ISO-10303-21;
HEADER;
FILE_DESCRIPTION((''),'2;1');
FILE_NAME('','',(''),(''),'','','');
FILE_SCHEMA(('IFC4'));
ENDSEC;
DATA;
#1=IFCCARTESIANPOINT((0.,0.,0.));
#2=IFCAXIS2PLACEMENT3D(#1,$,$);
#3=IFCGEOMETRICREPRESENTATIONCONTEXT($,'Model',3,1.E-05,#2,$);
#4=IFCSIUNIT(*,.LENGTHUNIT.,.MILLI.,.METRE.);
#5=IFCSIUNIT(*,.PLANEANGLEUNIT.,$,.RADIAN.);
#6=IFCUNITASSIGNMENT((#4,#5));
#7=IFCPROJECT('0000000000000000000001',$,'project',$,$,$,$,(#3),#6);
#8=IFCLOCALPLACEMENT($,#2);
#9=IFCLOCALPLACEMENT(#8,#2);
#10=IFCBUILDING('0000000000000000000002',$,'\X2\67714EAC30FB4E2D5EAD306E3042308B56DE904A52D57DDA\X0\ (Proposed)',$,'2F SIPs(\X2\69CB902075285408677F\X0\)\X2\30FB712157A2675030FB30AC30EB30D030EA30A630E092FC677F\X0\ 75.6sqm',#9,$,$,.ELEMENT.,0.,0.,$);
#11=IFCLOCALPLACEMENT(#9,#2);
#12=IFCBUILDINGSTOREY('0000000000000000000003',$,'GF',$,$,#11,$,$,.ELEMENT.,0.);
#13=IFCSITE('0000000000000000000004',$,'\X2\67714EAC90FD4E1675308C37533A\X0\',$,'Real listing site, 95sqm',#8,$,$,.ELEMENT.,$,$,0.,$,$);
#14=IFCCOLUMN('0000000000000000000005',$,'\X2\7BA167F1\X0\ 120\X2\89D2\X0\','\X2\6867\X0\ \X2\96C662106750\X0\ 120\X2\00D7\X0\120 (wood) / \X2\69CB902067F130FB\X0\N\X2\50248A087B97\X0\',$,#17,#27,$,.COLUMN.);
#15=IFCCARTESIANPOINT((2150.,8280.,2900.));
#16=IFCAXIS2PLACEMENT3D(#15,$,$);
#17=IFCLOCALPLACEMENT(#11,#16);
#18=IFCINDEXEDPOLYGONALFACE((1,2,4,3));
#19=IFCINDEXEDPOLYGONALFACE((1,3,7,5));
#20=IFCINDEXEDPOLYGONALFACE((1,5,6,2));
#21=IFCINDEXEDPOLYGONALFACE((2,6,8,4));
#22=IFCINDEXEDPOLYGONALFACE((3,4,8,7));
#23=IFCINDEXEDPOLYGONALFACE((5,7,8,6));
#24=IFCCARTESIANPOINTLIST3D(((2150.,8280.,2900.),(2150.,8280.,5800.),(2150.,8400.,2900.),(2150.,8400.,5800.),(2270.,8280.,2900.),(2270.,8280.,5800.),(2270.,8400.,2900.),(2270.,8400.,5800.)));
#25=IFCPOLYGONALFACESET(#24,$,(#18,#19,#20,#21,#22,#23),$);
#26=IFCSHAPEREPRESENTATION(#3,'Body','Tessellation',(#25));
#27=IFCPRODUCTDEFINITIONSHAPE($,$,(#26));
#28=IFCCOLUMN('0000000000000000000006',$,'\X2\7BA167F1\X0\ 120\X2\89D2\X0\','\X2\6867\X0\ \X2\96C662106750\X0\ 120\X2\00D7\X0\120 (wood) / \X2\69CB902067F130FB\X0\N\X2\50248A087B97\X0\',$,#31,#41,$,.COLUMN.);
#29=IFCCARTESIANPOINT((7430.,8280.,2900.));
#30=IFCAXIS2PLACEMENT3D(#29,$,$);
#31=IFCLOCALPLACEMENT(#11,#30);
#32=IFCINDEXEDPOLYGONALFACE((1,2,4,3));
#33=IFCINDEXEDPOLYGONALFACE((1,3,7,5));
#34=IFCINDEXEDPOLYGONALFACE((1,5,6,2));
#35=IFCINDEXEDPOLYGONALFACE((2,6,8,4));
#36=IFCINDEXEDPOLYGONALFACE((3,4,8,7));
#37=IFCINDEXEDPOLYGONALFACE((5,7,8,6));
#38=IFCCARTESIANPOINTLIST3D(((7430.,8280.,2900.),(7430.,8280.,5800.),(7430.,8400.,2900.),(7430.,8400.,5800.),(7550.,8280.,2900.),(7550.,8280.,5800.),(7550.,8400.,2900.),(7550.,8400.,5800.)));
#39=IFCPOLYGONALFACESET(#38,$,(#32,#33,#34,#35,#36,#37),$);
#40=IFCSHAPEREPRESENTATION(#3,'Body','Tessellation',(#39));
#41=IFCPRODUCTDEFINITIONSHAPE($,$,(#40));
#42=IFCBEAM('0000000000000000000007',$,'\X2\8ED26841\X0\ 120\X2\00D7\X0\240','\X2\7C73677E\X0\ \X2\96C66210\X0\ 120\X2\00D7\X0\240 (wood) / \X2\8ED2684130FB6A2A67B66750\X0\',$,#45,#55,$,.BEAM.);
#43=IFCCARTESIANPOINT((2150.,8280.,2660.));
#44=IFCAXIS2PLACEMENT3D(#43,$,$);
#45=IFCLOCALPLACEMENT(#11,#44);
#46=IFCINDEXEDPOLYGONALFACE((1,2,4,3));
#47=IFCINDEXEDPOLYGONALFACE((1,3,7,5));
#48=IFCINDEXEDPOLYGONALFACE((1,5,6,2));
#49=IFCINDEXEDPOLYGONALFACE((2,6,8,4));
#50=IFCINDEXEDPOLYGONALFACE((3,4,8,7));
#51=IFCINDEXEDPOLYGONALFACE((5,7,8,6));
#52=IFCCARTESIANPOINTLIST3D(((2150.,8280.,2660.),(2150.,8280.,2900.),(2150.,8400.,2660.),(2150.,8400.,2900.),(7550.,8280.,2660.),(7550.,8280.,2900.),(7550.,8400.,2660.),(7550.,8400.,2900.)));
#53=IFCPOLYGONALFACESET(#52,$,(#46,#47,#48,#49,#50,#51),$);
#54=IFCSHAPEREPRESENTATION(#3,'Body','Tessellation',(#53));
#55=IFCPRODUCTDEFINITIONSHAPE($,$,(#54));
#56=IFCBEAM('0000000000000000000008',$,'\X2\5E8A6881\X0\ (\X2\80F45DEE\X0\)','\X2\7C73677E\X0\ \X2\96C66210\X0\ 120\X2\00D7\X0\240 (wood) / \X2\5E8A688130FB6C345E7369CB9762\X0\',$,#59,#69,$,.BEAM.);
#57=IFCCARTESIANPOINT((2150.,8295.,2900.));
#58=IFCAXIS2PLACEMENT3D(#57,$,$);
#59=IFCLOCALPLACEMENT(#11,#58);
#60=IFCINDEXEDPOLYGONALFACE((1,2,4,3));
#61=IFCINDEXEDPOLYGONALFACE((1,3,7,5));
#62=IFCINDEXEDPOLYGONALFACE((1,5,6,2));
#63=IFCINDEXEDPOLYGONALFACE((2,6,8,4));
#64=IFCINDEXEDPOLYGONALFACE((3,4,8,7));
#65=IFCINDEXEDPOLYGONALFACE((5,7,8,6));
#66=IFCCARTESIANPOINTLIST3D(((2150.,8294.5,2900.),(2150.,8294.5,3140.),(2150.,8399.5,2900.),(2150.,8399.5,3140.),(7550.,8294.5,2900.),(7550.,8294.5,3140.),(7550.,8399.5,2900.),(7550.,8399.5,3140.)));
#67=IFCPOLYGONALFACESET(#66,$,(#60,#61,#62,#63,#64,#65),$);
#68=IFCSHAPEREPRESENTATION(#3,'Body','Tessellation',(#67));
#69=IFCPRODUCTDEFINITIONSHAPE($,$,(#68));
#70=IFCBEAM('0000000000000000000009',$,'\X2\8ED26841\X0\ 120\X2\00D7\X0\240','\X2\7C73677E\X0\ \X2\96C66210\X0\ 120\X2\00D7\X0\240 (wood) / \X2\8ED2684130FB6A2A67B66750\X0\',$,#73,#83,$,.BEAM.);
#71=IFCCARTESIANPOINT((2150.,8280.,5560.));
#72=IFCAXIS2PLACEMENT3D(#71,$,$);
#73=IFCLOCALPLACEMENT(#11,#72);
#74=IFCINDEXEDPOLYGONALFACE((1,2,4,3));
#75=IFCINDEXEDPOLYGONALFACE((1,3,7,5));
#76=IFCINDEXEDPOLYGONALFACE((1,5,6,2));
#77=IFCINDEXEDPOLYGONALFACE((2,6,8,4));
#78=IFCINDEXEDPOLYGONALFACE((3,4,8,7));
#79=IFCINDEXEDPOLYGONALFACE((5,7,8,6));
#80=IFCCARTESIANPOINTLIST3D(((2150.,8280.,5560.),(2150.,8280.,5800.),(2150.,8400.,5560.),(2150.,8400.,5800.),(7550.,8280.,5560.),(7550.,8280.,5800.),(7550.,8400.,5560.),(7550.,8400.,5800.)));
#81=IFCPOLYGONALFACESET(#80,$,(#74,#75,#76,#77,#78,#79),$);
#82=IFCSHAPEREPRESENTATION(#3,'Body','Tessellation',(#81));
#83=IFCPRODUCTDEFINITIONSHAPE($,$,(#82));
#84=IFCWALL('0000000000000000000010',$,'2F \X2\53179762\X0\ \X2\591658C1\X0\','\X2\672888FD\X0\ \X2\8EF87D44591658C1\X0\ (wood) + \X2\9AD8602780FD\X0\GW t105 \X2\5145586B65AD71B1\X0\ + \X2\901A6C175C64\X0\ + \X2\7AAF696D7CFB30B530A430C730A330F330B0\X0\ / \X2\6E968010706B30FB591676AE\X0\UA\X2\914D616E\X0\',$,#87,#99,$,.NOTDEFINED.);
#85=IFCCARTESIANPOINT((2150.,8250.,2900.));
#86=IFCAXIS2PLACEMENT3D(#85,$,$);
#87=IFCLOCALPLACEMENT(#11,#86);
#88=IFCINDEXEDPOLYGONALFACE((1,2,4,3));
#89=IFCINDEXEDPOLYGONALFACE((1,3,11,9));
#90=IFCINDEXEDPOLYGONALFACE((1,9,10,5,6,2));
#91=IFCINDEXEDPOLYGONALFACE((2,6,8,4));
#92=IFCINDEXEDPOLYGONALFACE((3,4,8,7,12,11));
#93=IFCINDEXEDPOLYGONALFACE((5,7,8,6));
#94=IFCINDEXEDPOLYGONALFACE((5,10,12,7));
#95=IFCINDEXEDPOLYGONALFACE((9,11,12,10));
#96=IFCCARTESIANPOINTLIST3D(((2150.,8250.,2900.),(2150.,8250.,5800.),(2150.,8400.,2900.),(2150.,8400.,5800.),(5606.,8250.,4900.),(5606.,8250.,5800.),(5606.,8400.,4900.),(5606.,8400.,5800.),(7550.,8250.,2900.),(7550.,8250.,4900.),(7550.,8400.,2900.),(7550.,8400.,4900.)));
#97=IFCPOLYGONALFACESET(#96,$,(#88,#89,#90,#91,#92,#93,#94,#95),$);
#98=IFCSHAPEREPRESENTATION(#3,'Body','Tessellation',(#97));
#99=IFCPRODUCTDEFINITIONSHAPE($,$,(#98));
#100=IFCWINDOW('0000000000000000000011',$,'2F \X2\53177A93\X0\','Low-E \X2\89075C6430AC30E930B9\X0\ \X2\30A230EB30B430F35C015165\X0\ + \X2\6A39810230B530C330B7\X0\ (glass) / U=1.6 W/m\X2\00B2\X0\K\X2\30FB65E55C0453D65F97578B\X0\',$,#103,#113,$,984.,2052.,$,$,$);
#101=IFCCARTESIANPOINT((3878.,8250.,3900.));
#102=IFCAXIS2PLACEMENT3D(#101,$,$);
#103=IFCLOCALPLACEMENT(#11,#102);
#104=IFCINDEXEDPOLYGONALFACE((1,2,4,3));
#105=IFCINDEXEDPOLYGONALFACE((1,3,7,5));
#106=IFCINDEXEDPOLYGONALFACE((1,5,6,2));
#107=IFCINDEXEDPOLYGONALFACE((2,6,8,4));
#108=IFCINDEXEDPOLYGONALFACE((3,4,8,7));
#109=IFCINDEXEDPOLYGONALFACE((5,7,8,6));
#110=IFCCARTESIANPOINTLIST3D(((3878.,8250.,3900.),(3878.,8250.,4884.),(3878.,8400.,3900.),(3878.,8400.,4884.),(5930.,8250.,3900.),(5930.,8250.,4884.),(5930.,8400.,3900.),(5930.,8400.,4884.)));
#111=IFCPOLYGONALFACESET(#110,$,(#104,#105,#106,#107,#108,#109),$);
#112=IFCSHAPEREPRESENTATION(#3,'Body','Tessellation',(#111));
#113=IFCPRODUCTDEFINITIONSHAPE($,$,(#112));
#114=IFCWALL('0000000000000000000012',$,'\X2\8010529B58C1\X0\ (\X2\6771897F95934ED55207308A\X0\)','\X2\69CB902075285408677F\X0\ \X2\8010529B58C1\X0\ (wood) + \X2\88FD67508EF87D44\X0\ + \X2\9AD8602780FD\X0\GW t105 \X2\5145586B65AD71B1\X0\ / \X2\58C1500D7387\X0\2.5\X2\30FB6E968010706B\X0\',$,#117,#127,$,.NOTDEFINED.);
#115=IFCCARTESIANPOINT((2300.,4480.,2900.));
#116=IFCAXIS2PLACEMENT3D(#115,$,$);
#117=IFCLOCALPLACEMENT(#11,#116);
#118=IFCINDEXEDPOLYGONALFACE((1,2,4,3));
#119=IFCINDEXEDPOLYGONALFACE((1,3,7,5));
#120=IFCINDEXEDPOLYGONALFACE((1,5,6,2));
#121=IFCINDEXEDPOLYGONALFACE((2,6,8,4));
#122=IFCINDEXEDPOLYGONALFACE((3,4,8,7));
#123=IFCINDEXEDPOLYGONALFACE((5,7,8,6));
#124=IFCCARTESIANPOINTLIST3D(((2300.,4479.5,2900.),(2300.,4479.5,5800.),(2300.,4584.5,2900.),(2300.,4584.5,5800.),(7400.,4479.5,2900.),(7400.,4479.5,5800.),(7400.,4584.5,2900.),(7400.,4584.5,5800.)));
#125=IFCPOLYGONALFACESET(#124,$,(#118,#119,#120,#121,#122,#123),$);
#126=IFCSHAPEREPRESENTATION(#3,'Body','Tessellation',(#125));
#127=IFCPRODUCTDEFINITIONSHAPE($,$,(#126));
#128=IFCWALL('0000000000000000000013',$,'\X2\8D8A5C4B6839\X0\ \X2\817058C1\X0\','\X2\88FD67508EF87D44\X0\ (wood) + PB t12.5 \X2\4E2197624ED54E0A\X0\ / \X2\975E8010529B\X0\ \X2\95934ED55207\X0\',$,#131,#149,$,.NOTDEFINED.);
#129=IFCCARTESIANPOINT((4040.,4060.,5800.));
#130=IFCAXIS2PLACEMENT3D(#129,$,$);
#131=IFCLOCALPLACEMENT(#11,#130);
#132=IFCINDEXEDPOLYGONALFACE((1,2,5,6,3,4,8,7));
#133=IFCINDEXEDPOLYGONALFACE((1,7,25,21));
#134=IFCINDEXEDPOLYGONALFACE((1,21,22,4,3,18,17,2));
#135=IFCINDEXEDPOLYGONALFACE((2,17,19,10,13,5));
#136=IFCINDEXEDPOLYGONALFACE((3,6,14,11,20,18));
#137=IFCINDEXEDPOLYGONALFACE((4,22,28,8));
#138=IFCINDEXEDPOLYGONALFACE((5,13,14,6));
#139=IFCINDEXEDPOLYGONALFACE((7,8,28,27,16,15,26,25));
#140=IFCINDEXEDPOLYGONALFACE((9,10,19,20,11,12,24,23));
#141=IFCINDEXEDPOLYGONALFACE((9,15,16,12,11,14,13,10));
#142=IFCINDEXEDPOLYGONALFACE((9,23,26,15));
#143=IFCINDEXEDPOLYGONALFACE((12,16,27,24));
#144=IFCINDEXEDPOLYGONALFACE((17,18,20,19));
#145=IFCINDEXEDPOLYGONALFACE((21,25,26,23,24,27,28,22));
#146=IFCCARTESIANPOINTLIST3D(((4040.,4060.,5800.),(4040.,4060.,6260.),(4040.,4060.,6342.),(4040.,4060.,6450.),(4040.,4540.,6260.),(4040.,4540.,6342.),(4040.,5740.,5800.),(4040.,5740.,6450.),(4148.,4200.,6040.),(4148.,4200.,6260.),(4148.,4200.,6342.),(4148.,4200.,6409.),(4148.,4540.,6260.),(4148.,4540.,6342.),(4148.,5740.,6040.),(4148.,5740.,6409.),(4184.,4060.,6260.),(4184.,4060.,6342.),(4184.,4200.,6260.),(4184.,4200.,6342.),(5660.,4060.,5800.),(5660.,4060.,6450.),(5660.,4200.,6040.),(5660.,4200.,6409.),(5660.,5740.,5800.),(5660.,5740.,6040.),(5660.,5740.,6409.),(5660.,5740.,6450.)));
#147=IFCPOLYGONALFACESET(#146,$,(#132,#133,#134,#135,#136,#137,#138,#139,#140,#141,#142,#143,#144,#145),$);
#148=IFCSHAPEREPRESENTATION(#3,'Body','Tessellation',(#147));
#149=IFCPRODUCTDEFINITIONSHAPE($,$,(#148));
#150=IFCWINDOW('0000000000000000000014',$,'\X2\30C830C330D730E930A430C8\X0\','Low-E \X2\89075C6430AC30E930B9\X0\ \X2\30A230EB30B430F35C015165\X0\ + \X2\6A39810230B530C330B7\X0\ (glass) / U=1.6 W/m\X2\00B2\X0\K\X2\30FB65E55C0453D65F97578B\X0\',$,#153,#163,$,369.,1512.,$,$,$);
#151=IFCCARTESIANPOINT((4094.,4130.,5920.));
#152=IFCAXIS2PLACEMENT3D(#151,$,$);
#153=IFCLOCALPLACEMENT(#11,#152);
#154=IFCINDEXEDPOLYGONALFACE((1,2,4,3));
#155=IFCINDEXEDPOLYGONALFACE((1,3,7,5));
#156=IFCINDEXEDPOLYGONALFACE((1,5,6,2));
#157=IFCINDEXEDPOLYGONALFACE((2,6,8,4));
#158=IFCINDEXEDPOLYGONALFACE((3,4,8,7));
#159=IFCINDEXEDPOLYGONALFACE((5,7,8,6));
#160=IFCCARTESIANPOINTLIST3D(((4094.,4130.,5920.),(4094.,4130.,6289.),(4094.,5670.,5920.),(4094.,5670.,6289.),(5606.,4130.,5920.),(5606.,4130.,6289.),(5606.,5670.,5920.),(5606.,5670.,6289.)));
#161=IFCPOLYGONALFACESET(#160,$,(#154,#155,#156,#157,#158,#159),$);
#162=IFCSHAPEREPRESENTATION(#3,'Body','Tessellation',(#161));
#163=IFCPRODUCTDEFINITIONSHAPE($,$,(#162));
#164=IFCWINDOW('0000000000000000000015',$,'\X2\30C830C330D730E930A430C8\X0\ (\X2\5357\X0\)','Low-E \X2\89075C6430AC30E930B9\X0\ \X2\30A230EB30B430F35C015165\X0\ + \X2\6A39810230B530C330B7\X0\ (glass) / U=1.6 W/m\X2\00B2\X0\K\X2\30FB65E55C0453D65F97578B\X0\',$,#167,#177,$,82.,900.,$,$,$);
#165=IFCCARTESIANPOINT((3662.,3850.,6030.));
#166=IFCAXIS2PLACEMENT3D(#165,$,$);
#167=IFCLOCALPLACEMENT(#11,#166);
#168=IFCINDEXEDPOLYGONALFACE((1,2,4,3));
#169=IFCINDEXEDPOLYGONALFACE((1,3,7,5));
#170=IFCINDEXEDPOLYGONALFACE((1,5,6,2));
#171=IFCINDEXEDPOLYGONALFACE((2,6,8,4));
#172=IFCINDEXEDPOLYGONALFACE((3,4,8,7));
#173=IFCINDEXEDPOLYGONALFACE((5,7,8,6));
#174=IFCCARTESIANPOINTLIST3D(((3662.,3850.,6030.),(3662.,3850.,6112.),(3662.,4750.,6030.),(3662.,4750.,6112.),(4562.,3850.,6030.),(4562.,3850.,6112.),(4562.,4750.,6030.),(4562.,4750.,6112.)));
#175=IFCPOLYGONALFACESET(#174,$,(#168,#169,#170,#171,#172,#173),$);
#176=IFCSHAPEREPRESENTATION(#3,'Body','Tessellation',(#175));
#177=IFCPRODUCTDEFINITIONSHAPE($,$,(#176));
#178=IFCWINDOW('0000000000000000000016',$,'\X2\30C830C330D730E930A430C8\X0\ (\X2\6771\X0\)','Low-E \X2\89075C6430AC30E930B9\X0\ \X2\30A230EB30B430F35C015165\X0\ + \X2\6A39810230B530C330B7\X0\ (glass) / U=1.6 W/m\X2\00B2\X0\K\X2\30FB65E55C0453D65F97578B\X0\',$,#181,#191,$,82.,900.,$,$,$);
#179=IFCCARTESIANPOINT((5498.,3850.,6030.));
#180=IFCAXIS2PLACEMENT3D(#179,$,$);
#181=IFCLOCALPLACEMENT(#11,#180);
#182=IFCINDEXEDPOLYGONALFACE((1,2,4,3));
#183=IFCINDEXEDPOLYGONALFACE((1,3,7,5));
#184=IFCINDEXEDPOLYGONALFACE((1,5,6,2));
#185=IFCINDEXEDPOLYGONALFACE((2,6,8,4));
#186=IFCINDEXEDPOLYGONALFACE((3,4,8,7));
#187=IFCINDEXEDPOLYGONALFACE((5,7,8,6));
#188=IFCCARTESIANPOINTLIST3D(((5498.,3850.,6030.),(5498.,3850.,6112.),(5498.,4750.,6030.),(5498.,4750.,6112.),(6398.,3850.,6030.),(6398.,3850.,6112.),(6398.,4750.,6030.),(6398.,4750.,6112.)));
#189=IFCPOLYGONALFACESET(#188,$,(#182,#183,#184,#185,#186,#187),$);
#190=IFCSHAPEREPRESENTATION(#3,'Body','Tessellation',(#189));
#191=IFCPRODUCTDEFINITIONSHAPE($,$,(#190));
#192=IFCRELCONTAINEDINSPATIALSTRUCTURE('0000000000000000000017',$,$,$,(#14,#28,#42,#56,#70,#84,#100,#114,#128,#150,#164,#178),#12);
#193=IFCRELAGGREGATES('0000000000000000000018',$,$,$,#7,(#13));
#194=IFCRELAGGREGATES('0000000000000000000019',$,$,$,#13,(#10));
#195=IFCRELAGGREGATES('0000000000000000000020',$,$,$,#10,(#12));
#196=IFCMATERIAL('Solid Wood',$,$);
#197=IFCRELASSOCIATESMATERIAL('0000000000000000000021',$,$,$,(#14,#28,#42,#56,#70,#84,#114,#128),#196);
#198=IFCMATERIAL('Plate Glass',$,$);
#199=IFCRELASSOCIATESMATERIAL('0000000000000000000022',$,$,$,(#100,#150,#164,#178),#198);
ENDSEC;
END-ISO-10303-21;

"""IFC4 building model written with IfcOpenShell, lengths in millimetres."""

from ifc_helpers import new_model, si_unit, frame, frame_2d, origin, place, context, project, spatial, rectangle, extrude, material, element, fill, save


model = new_model("IFC4")

# Units and contexts
model_context = context("Model", 3, precision=1e-05, world=origin())
ifc_project = project(units=[si_unit("LENGTHUNIT", "METRE", prefix="MILLI"), si_unit("PLANEANGLEUNIT", "RADIAN")], contexts=[model_context])

# Site, building, storey
site_placement = place(None, origin())
site = spatial("IfcSite", under=ifc_project, at=site_placement, Name="東京都世田谷区", ObjectType="Real listing site, 95sqm", CompositionType="ELEMENT", RefElevation=0.0)
building_placement = place(site_placement, origin())
building = spatial("IfcBuilding", under=site, at=building_placement, Name="東京・中庭のある回遊動線 (Proposed)", ObjectType="2F SIPs(構造用合板)・無垢材・ガルバリウム鋼板 75.6sqm", CompositionType="ELEMENT", ElevationOfRefHeight=0.0, ElevationOfTerrain=0.0)
storey_placement = place(building_placement, origin())
storey = spatial("IfcBuildingStorey", under=building, at=storey_placement, Name="GF", CompositionType="ELEMENT", Elevation=0.0)

# Columns
ifc_material_1 = material(Name="Solid Wood")
column_1_placement = place(storey_placement, frame((2150.0, 8280.0, 2900.0)))
element("IfcColumn", 1, at=column_1_placement, inside=storey, material=ifc_material_1, Name="管柱 120角", Description="桧 集成材 120×120 (wood) / 構造柱・N値計算", PredefinedType="COLUMN", context=model_context, shape_type="SweptSolid", body=[
    extrude(rectangle(XDim=120.0, YDim=120.0, at=frame_2d((60.0, 60.0))), frame((2150.0, 8280.0, 2900.0)), (0.0, 0.0, 1.0), 2900.0),
])
column_2_placement = place(storey_placement, frame((7430.0, 8280.0, 2900.0)))
element("IfcColumn", 2, at=column_2_placement, inside=storey, material=ifc_material_1, Name="管柱 120角", Description="桧 集成材 120×120 (wood) / 構造柱・N値計算", PredefinedType="COLUMN", context=model_context, shape_type="SweptSolid", body=[
    extrude(rectangle(XDim=120.0, YDim=120.0, at=frame_2d((60.0, 60.0))), frame((7430.0, 8280.0, 2900.0)), (0.0, 0.0, 1.0), 2900.0),
])

# Beams
beam_1_placement = place(storey_placement, frame((2150.0, 8280.0, 2660.0)))
element("IfcBeam", 3, at=beam_1_placement, inside=storey, material=ifc_material_1, Name="軒桁 120×240", Description="米松 集成 120×240 (wood) / 軒桁・横架材", PredefinedType="BEAM", context=model_context, shape_type="SweptSolid", body=[
    extrude(rectangle(XDim=5400.0, YDim=120.0, at=frame_2d((2700.0, 60.0))), frame((2150.0, 8280.0, 2660.0)), (0.0, 0.0, 1.0), 240.0),
])
beam_2_placement = place(storey_placement, frame((2150.0, 8295.0, 2900.0)))
element("IfcBeam", 4, at=beam_2_placement, inside=storey, material=ifc_material_1, Name="床梁 (胴差)", Description="米松 集成 120×240 (wood) / 床梁・水平構面", PredefinedType="BEAM", context=model_context, shape_type="SweptSolid", body=[
    extrude(rectangle(XDim=5400.0, YDim=105.0, at=frame_2d((2700.0, 52.0))), frame((2150.0, 8295.0, 2900.0)), (0.0, 0.0, 1.0), 240.0),
])
beam_3_placement = place(storey_placement, frame((2150.0, 8280.0, 5560.0)))
element("IfcBeam", 5, at=beam_3_placement, inside=storey, material=ifc_material_1, Name="軒桁 120×240", Description="米松 集成 120×240 (wood) / 軒桁・横架材", PredefinedType="BEAM", context=model_context, shape_type="SweptSolid", body=[
    extrude(rectangle(XDim=5400.0, YDim=120.0, at=frame_2d((2700.0, 60.0))), frame((2150.0, 8280.0, 5560.0)), (0.0, 0.0, 1.0), 240.0),
])

# Wall, opening, window
wall_1_placement = place(storey_placement, frame((2150.0, 8250.0, 2900.0)))
wall_1 = element("IfcWall", 6, at=wall_1_placement, inside=storey, material=ifc_material_1, Name="2F 北面 外壁", Description="木製 軸組外壁 (wood) + 高性能GW t105 充填断熱 + 通気層 + 窯業系サイディング / 準耐火・外皮UA配慮", PredefinedType="NOTDEFINED", context=model_context, shape_type="SweptSolid", body=[
    extrude(rectangle(XDim=5400.0, YDim=150.0, at=frame_2d((2700.0, 75.0))), frame((2150.0, 8250.0, 2900.0)), (0.0, 0.0, 1.0), 2900.0),
])
opening_1_placement = place(storey_placement, frame((3878.0, 8250.0, 3900.0)))
opening_1 = element("IfcOpeningElement", 7, at=opening_1_placement, cuts=wall_1, PredefinedType="NOTDEFINED", context=model_context, shape_type="SweptSolid", body=[
    extrude(rectangle(XDim=2052.0, YDim=150.0, at=frame_2d((1026.0, 75.0))), frame((3878.0, 8250.0, 3900.0)), (0.0, 0.0, 1.0), 984.0),
])
ifc_material_2 = material(Name="Plate Glass")
window_1_placement = place(storey_placement, frame((3878.0, 8250.0, 3900.0)))
window_1 = element("IfcWindow", 8, at=window_1_placement, inside=storey, material=ifc_material_2, Name="2F 北窓", Description="Low-E 複層ガラス アルゴン封入 + 樹脂サッシ (glass) / U=1.6 W/m²K・日射取得型", OverallHeight=984.0, OverallWidth=2052.0, context=model_context, shape_type="SweptSolid", body=[
    extrude(rectangle(XDim=2052.0, YDim=150.0, at=frame_2d((1026.0, 75.0))), frame((3878.0, 8250.0, 3900.0)), (0.0, 0.0, 1.0), 984.0),
])
fill(opening_1, window_1)

# Wall
wall_2_placement = place(storey_placement, frame((2300.0, 4480.0, 2900.0)))
element("IfcWall", 9, at=wall_2_placement, inside=storey, material=ifc_material_1, Name="耐力壁 (東西間仕切り)", Description="構造用合板 耐力壁 (wood) + 製材軸組 + 高性能GW t105 充填断熱 / 壁倍率2.5・準耐火", PredefinedType="NOTDEFINED", context=model_context, shape_type="SweptSolid", body=[
    extrude(rectangle(XDim=5100.0, YDim=105.0, at=frame_2d((2550.0, 52.0))), frame((2300.0, 4480.0, 2900.0)), (0.0, 0.0, 1.0), 2900.0),
])

# Wall, openings, windows
wall_3_placement = place(storey_placement, frame((4040.0, 4060.0, 5800.0)))
wall_3 = element("IfcWall", 10, at=wall_3_placement, inside=storey, material=ifc_material_1, Name="越屋根 腰壁", Description="製材軸組 (wood) + PB t12.5 両面仕上 / 非耐力 間仕切", PredefinedType="NOTDEFINED", context=model_context, shape_type="SweptSolid", body=[
    extrude(rectangle(XDim=1620.0, YDim=1680.0, at=frame_2d((810.0, 840.0))), frame((4040.0, 4060.0, 5800.0)), (0.0, 0.0, 1.0), 650.0),
])
opening_2_placement = place(storey_placement, frame((4094.0, 4130.0, 5920.0)))
opening_2 = element("IfcOpeningElement", 11, at=opening_2_placement, cuts=wall_3, PredefinedType="NOTDEFINED", context=model_context, shape_type="SweptSolid", body=[
    extrude(rectangle(XDim=1512.0, YDim=1540.0, at=frame_2d((756.0, 770.0))), frame((4094.0, 4130.0, 5920.0)), (0.0, 0.0, 1.0), 369.0),
])
opening_3_placement = place(storey_placement, frame((3662.0, 3850.0, 6030.0)))
opening_3 = element("IfcOpeningElement", 12, at=opening_3_placement, cuts=wall_3, PredefinedType="NOTDEFINED", context=model_context, shape_type="SweptSolid", body=[
    extrude(rectangle(XDim=900.0, YDim=900.0, at=frame_2d((450.0, 450.0))), frame((3662.0, 3850.0, 6030.0)), (0.0, 0.0, 1.0), 82.0),
])
opening_4_placement = place(storey_placement, frame((5498.0, 3850.0, 6030.0)))
opening_4 = element("IfcOpeningElement", 13, at=opening_4_placement, cuts=wall_3, PredefinedType="NOTDEFINED", context=model_context, shape_type="SweptSolid", body=[
    extrude(rectangle(XDim=900.0, YDim=900.0, at=frame_2d((450.0, 450.0))), frame((5498.0, 3850.0, 6030.0)), (0.0, 0.0, 1.0), 82.0),
])
window_2_placement = place(storey_placement, frame((4094.0, 4130.0, 5920.0)))
window_2 = element("IfcWindow", 14, at=window_2_placement, inside=storey, material=ifc_material_2, Name="トップライト", Description="Low-E 複層ガラス アルゴン封入 + 樹脂サッシ (glass) / U=1.6 W/m²K・日射取得型", OverallHeight=369.0, OverallWidth=1512.0, context=model_context, shape_type="SweptSolid", body=[
    extrude(rectangle(XDim=1512.0, YDim=1540.0, at=frame_2d((756.0, 770.0))), frame((4094.0, 4130.0, 5920.0)), (0.0, 0.0, 1.0), 369.0),
])
fill(opening_2, window_2)
window_3_placement = place(storey_placement, frame((3662.0, 3850.0, 6030.0)))
window_3 = element("IfcWindow", 15, at=window_3_placement, inside=storey, material=ifc_material_2, Name="トップライト (南)", Description="Low-E 複層ガラス アルゴン封入 + 樹脂サッシ (glass) / U=1.6 W/m²K・日射取得型", OverallHeight=82.0, OverallWidth=900.0, context=model_context, shape_type="SweptSolid", body=[
    extrude(rectangle(XDim=900.0, YDim=900.0, at=frame_2d((450.0, 450.0))), frame((3662.0, 3850.0, 6030.0)), (0.0, 0.0, 1.0), 82.0),
])
fill(opening_3, window_3)
window_4_placement = place(storey_placement, frame((5498.0, 3850.0, 6030.0)))
window_4 = element("IfcWindow", 16, at=window_4_placement, inside=storey, material=ifc_material_2, Name="トップライト (東)", Description="Low-E 複層ガラス アルゴン封入 + 樹脂サッシ (glass) / U=1.6 W/m²K・日射取得型", OverallHeight=82.0, OverallWidth=900.0, context=model_context, shape_type="SweptSolid", body=[
    extrude(rectangle(XDim=900.0, YDim=900.0, at=frame_2d((450.0, 450.0))), frame((5498.0, 3850.0, 6030.0)), (0.0, 0.0, 1.0), 82.0),
])
fill(opening_4, window_4)

save(model, "model.ifc")
